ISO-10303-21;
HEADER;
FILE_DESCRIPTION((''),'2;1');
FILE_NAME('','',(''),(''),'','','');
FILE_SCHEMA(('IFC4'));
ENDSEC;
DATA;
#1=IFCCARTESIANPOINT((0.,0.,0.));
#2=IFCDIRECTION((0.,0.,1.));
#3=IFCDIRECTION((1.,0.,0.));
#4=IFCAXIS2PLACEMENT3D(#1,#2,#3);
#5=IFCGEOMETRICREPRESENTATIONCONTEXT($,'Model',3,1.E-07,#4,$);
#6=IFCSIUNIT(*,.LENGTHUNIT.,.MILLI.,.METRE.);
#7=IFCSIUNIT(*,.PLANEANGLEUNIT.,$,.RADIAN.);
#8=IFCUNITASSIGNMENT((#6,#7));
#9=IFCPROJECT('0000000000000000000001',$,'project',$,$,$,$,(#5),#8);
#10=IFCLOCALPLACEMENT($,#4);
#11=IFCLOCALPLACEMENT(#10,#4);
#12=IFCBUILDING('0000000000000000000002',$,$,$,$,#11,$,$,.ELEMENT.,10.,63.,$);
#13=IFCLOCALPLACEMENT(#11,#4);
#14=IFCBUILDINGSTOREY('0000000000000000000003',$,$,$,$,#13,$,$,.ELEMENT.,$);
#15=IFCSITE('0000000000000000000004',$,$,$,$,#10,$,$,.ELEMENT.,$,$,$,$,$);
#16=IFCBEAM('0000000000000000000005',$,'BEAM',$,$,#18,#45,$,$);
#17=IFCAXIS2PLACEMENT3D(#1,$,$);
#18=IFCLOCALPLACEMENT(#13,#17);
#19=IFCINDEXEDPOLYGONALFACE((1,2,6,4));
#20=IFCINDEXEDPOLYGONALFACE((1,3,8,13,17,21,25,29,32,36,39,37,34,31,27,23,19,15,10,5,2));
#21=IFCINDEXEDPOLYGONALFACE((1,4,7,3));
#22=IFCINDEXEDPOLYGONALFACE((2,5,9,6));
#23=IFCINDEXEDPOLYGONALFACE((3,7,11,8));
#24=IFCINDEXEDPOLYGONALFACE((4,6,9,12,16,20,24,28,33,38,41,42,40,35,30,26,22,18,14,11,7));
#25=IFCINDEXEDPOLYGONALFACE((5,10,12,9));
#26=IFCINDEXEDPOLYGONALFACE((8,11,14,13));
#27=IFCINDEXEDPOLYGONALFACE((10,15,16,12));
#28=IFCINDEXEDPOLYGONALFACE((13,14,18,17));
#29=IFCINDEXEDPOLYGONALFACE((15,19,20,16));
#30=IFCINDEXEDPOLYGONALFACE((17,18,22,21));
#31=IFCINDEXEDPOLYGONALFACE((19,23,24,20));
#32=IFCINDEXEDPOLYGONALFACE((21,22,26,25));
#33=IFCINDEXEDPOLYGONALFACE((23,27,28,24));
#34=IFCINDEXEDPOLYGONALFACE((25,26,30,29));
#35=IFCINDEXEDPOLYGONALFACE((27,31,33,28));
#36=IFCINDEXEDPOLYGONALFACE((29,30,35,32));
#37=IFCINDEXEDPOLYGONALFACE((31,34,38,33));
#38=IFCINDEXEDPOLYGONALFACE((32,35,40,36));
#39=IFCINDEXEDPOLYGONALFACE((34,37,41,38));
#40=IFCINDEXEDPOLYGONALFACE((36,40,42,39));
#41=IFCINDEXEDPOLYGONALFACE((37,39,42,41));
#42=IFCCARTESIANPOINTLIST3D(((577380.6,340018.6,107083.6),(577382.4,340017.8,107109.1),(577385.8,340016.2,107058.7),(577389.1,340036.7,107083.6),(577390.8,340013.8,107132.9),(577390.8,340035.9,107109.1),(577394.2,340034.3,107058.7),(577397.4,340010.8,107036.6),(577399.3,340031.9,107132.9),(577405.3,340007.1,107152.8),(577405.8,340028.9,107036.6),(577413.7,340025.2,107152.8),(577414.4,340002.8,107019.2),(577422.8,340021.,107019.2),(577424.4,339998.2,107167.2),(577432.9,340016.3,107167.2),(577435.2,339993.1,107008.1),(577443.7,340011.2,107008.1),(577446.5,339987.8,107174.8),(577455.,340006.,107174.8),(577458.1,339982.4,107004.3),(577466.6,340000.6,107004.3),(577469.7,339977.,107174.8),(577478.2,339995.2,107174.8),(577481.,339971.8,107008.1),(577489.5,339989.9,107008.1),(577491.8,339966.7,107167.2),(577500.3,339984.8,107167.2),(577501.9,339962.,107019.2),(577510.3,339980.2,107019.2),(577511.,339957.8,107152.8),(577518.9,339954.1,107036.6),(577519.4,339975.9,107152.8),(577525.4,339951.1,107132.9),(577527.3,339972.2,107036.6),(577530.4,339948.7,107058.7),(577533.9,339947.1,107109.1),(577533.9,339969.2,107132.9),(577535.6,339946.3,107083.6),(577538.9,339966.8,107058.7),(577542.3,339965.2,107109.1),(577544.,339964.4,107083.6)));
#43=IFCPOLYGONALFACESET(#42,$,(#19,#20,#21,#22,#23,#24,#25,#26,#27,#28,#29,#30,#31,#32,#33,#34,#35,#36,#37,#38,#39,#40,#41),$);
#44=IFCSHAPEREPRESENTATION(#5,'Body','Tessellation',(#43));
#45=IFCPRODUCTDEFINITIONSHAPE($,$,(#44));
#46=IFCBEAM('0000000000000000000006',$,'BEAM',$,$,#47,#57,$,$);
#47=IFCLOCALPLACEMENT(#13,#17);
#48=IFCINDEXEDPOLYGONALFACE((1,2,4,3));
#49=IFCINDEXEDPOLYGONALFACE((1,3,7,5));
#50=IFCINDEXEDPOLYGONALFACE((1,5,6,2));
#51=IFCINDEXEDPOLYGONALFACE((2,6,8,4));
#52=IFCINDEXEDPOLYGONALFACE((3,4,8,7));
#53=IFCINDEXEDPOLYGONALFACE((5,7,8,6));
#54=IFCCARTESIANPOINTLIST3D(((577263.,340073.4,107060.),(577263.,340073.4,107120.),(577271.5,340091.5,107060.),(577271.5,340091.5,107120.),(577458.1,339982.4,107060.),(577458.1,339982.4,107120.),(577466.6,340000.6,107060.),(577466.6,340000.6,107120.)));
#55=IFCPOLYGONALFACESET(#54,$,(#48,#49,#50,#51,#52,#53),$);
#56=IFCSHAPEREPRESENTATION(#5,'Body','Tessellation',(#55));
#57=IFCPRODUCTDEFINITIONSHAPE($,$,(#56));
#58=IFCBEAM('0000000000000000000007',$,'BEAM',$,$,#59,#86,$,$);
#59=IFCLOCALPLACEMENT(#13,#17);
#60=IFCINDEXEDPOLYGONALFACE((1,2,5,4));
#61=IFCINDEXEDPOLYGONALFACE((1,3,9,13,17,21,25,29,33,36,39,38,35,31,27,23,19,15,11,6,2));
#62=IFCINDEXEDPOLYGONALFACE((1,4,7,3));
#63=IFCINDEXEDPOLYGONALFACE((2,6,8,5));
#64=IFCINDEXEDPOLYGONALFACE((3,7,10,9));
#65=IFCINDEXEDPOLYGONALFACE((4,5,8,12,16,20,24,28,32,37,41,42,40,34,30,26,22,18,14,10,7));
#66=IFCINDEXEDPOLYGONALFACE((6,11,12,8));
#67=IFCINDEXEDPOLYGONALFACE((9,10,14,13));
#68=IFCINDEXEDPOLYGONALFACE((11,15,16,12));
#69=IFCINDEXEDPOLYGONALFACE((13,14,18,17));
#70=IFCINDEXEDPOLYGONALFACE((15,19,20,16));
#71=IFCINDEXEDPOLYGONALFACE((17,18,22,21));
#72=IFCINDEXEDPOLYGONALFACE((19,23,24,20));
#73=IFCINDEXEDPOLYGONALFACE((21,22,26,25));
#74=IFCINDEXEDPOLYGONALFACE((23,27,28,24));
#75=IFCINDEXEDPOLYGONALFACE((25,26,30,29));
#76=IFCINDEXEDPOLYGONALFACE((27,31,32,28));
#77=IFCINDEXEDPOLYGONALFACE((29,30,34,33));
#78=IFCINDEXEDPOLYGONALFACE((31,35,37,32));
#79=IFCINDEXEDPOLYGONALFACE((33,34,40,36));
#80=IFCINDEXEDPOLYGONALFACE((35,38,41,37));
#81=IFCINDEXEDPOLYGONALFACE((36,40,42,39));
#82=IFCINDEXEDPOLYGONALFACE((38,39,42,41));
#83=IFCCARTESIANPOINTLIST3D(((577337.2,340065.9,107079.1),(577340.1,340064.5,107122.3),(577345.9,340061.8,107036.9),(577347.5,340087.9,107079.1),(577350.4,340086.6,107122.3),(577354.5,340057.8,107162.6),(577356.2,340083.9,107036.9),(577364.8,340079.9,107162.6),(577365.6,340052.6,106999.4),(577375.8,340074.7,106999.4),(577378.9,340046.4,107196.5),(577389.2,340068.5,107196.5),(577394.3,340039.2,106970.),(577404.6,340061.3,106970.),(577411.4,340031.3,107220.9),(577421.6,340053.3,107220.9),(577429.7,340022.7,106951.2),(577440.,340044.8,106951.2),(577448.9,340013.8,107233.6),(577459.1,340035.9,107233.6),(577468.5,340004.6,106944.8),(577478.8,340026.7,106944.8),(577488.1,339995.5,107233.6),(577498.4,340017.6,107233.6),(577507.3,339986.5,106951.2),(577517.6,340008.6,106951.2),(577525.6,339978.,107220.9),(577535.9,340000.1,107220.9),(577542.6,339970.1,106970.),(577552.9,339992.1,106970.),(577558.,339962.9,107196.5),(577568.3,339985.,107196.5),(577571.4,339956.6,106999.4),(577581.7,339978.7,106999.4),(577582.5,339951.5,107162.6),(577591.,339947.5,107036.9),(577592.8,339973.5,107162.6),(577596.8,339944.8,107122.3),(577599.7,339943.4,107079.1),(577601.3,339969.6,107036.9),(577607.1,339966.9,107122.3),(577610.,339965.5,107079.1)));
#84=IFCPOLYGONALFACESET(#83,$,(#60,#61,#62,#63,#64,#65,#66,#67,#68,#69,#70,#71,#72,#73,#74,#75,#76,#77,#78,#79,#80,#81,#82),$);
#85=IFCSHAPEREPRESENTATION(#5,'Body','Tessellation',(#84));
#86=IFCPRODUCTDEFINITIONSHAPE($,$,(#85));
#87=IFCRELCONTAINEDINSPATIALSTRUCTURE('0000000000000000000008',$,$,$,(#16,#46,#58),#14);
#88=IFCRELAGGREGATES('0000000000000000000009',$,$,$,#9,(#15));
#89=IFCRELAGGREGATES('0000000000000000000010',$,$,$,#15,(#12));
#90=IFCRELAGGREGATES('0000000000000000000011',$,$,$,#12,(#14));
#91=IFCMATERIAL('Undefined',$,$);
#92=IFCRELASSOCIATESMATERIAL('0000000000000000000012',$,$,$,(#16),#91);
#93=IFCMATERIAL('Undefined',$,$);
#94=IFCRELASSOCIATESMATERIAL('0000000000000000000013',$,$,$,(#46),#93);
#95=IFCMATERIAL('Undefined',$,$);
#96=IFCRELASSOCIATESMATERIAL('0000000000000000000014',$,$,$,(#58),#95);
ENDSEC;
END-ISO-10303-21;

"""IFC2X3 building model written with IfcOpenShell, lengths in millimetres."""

from ifc_helpers import new_model, si_unit, frame, origin_with_axes, origin_2d_with_axis, place, context, project, spatial, rectangle, circle, extrude, material, element, save


model = new_model("IFC2X3")

# Units and contexts
model_context = context("Model", 3, precision=1e-07, world=origin_with_axes())
ifc_project = project(units=[si_unit("LENGTHUNIT", "METRE", prefix="MILLI"), si_unit("PLANEANGLEUNIT", "RADIAN")], contexts=[model_context])

# Site, building, storey
site_placement = place(None, origin_with_axes())
site = spatial("IfcSite", under=ifc_project, at=site_placement, CompositionType="ELEMENT")
building_placement = place(site_placement, origin_with_axes())
building = spatial("IfcBuilding", under=site, at=building_placement, CompositionType="ELEMENT", ElevationOfRefHeight=10.0, ElevationOfTerrain=63.0)
storey_placement = place(building_placement, origin_with_axes())
storey = spatial("IfcBuildingStorey", under=building, at=storey_placement, CompositionType="ELEMENT")

# Beams
ifc_material_1 = material(Name="Undefined")
beam_1_placement = place(storey_placement, frame((577462.3, 339991.5, 107090.0), z_axis=(0.422618, 0.906308, 0.0), x_axis=(-0.906308, 0.422618, 0.0)))
element("IfcBeam", 1, at=beam_1_placement, inside=storey, material=ifc_material_1, Name="BEAM", context=model_context, shape_type="SweptSolid", body=[
    extrude(circle(Radius=85.7, at=origin_2d_with_axis()), frame((0.0, 0.0, -10.0), z_axis=(0.0, 0.0, 1.0), x_axis=(0.0, -1.0, 0.0)), (0.0, 0.0, 1.0), 20.0),
])
ifc_material_2 = material(Name="Undefined")
beam_2_placement = place(storey_placement, frame((577364.8, 340037.0, 107090.0), z_axis=(0.0, 0.0, 1.0), x_axis=(-0.906308, 0.422618, 0.0)))
element("IfcBeam", 2, at=beam_2_placement, inside=storey, material=ifc_material_2, Name="BEAM", context=model_context, shape_type="SweptSolid", body=[
    extrude(rectangle(XDim=20.0, YDim=215.2, at=origin_2d_with_axis()), frame((0.0, 0.0, -30.0), z_axis=(0.0, 0.0, 1.0), x_axis=(0.0, -1.0, 0.0)), (0.0, 0.0, 1.0), 60.0),
])
ifc_material_3 = material(Name="Undefined")
beam_3_placement = place(storey_placement, frame((577473.6, 340015.7, 107090.0), z_axis=(0.422618, 0.906308, 0.0), x_axis=(-0.906308, 0.422618, 0.0)))
element("IfcBeam", 3, at=beam_3_placement, inside=storey, material=ifc_material_3, Name="BEAM", context=model_context, shape_type="SweptSolid", body=[
    extrude(circle(Radius=145.2, at=origin_2d_with_axis()), frame((0.0, 0.0, -12.2), z_axis=(0.0, 0.0, 1.0), x_axis=(0.0, -1.0, 0.0)), (0.0, 0.0, 1.0), 24.4),
])

save(model, "model.ifc")
